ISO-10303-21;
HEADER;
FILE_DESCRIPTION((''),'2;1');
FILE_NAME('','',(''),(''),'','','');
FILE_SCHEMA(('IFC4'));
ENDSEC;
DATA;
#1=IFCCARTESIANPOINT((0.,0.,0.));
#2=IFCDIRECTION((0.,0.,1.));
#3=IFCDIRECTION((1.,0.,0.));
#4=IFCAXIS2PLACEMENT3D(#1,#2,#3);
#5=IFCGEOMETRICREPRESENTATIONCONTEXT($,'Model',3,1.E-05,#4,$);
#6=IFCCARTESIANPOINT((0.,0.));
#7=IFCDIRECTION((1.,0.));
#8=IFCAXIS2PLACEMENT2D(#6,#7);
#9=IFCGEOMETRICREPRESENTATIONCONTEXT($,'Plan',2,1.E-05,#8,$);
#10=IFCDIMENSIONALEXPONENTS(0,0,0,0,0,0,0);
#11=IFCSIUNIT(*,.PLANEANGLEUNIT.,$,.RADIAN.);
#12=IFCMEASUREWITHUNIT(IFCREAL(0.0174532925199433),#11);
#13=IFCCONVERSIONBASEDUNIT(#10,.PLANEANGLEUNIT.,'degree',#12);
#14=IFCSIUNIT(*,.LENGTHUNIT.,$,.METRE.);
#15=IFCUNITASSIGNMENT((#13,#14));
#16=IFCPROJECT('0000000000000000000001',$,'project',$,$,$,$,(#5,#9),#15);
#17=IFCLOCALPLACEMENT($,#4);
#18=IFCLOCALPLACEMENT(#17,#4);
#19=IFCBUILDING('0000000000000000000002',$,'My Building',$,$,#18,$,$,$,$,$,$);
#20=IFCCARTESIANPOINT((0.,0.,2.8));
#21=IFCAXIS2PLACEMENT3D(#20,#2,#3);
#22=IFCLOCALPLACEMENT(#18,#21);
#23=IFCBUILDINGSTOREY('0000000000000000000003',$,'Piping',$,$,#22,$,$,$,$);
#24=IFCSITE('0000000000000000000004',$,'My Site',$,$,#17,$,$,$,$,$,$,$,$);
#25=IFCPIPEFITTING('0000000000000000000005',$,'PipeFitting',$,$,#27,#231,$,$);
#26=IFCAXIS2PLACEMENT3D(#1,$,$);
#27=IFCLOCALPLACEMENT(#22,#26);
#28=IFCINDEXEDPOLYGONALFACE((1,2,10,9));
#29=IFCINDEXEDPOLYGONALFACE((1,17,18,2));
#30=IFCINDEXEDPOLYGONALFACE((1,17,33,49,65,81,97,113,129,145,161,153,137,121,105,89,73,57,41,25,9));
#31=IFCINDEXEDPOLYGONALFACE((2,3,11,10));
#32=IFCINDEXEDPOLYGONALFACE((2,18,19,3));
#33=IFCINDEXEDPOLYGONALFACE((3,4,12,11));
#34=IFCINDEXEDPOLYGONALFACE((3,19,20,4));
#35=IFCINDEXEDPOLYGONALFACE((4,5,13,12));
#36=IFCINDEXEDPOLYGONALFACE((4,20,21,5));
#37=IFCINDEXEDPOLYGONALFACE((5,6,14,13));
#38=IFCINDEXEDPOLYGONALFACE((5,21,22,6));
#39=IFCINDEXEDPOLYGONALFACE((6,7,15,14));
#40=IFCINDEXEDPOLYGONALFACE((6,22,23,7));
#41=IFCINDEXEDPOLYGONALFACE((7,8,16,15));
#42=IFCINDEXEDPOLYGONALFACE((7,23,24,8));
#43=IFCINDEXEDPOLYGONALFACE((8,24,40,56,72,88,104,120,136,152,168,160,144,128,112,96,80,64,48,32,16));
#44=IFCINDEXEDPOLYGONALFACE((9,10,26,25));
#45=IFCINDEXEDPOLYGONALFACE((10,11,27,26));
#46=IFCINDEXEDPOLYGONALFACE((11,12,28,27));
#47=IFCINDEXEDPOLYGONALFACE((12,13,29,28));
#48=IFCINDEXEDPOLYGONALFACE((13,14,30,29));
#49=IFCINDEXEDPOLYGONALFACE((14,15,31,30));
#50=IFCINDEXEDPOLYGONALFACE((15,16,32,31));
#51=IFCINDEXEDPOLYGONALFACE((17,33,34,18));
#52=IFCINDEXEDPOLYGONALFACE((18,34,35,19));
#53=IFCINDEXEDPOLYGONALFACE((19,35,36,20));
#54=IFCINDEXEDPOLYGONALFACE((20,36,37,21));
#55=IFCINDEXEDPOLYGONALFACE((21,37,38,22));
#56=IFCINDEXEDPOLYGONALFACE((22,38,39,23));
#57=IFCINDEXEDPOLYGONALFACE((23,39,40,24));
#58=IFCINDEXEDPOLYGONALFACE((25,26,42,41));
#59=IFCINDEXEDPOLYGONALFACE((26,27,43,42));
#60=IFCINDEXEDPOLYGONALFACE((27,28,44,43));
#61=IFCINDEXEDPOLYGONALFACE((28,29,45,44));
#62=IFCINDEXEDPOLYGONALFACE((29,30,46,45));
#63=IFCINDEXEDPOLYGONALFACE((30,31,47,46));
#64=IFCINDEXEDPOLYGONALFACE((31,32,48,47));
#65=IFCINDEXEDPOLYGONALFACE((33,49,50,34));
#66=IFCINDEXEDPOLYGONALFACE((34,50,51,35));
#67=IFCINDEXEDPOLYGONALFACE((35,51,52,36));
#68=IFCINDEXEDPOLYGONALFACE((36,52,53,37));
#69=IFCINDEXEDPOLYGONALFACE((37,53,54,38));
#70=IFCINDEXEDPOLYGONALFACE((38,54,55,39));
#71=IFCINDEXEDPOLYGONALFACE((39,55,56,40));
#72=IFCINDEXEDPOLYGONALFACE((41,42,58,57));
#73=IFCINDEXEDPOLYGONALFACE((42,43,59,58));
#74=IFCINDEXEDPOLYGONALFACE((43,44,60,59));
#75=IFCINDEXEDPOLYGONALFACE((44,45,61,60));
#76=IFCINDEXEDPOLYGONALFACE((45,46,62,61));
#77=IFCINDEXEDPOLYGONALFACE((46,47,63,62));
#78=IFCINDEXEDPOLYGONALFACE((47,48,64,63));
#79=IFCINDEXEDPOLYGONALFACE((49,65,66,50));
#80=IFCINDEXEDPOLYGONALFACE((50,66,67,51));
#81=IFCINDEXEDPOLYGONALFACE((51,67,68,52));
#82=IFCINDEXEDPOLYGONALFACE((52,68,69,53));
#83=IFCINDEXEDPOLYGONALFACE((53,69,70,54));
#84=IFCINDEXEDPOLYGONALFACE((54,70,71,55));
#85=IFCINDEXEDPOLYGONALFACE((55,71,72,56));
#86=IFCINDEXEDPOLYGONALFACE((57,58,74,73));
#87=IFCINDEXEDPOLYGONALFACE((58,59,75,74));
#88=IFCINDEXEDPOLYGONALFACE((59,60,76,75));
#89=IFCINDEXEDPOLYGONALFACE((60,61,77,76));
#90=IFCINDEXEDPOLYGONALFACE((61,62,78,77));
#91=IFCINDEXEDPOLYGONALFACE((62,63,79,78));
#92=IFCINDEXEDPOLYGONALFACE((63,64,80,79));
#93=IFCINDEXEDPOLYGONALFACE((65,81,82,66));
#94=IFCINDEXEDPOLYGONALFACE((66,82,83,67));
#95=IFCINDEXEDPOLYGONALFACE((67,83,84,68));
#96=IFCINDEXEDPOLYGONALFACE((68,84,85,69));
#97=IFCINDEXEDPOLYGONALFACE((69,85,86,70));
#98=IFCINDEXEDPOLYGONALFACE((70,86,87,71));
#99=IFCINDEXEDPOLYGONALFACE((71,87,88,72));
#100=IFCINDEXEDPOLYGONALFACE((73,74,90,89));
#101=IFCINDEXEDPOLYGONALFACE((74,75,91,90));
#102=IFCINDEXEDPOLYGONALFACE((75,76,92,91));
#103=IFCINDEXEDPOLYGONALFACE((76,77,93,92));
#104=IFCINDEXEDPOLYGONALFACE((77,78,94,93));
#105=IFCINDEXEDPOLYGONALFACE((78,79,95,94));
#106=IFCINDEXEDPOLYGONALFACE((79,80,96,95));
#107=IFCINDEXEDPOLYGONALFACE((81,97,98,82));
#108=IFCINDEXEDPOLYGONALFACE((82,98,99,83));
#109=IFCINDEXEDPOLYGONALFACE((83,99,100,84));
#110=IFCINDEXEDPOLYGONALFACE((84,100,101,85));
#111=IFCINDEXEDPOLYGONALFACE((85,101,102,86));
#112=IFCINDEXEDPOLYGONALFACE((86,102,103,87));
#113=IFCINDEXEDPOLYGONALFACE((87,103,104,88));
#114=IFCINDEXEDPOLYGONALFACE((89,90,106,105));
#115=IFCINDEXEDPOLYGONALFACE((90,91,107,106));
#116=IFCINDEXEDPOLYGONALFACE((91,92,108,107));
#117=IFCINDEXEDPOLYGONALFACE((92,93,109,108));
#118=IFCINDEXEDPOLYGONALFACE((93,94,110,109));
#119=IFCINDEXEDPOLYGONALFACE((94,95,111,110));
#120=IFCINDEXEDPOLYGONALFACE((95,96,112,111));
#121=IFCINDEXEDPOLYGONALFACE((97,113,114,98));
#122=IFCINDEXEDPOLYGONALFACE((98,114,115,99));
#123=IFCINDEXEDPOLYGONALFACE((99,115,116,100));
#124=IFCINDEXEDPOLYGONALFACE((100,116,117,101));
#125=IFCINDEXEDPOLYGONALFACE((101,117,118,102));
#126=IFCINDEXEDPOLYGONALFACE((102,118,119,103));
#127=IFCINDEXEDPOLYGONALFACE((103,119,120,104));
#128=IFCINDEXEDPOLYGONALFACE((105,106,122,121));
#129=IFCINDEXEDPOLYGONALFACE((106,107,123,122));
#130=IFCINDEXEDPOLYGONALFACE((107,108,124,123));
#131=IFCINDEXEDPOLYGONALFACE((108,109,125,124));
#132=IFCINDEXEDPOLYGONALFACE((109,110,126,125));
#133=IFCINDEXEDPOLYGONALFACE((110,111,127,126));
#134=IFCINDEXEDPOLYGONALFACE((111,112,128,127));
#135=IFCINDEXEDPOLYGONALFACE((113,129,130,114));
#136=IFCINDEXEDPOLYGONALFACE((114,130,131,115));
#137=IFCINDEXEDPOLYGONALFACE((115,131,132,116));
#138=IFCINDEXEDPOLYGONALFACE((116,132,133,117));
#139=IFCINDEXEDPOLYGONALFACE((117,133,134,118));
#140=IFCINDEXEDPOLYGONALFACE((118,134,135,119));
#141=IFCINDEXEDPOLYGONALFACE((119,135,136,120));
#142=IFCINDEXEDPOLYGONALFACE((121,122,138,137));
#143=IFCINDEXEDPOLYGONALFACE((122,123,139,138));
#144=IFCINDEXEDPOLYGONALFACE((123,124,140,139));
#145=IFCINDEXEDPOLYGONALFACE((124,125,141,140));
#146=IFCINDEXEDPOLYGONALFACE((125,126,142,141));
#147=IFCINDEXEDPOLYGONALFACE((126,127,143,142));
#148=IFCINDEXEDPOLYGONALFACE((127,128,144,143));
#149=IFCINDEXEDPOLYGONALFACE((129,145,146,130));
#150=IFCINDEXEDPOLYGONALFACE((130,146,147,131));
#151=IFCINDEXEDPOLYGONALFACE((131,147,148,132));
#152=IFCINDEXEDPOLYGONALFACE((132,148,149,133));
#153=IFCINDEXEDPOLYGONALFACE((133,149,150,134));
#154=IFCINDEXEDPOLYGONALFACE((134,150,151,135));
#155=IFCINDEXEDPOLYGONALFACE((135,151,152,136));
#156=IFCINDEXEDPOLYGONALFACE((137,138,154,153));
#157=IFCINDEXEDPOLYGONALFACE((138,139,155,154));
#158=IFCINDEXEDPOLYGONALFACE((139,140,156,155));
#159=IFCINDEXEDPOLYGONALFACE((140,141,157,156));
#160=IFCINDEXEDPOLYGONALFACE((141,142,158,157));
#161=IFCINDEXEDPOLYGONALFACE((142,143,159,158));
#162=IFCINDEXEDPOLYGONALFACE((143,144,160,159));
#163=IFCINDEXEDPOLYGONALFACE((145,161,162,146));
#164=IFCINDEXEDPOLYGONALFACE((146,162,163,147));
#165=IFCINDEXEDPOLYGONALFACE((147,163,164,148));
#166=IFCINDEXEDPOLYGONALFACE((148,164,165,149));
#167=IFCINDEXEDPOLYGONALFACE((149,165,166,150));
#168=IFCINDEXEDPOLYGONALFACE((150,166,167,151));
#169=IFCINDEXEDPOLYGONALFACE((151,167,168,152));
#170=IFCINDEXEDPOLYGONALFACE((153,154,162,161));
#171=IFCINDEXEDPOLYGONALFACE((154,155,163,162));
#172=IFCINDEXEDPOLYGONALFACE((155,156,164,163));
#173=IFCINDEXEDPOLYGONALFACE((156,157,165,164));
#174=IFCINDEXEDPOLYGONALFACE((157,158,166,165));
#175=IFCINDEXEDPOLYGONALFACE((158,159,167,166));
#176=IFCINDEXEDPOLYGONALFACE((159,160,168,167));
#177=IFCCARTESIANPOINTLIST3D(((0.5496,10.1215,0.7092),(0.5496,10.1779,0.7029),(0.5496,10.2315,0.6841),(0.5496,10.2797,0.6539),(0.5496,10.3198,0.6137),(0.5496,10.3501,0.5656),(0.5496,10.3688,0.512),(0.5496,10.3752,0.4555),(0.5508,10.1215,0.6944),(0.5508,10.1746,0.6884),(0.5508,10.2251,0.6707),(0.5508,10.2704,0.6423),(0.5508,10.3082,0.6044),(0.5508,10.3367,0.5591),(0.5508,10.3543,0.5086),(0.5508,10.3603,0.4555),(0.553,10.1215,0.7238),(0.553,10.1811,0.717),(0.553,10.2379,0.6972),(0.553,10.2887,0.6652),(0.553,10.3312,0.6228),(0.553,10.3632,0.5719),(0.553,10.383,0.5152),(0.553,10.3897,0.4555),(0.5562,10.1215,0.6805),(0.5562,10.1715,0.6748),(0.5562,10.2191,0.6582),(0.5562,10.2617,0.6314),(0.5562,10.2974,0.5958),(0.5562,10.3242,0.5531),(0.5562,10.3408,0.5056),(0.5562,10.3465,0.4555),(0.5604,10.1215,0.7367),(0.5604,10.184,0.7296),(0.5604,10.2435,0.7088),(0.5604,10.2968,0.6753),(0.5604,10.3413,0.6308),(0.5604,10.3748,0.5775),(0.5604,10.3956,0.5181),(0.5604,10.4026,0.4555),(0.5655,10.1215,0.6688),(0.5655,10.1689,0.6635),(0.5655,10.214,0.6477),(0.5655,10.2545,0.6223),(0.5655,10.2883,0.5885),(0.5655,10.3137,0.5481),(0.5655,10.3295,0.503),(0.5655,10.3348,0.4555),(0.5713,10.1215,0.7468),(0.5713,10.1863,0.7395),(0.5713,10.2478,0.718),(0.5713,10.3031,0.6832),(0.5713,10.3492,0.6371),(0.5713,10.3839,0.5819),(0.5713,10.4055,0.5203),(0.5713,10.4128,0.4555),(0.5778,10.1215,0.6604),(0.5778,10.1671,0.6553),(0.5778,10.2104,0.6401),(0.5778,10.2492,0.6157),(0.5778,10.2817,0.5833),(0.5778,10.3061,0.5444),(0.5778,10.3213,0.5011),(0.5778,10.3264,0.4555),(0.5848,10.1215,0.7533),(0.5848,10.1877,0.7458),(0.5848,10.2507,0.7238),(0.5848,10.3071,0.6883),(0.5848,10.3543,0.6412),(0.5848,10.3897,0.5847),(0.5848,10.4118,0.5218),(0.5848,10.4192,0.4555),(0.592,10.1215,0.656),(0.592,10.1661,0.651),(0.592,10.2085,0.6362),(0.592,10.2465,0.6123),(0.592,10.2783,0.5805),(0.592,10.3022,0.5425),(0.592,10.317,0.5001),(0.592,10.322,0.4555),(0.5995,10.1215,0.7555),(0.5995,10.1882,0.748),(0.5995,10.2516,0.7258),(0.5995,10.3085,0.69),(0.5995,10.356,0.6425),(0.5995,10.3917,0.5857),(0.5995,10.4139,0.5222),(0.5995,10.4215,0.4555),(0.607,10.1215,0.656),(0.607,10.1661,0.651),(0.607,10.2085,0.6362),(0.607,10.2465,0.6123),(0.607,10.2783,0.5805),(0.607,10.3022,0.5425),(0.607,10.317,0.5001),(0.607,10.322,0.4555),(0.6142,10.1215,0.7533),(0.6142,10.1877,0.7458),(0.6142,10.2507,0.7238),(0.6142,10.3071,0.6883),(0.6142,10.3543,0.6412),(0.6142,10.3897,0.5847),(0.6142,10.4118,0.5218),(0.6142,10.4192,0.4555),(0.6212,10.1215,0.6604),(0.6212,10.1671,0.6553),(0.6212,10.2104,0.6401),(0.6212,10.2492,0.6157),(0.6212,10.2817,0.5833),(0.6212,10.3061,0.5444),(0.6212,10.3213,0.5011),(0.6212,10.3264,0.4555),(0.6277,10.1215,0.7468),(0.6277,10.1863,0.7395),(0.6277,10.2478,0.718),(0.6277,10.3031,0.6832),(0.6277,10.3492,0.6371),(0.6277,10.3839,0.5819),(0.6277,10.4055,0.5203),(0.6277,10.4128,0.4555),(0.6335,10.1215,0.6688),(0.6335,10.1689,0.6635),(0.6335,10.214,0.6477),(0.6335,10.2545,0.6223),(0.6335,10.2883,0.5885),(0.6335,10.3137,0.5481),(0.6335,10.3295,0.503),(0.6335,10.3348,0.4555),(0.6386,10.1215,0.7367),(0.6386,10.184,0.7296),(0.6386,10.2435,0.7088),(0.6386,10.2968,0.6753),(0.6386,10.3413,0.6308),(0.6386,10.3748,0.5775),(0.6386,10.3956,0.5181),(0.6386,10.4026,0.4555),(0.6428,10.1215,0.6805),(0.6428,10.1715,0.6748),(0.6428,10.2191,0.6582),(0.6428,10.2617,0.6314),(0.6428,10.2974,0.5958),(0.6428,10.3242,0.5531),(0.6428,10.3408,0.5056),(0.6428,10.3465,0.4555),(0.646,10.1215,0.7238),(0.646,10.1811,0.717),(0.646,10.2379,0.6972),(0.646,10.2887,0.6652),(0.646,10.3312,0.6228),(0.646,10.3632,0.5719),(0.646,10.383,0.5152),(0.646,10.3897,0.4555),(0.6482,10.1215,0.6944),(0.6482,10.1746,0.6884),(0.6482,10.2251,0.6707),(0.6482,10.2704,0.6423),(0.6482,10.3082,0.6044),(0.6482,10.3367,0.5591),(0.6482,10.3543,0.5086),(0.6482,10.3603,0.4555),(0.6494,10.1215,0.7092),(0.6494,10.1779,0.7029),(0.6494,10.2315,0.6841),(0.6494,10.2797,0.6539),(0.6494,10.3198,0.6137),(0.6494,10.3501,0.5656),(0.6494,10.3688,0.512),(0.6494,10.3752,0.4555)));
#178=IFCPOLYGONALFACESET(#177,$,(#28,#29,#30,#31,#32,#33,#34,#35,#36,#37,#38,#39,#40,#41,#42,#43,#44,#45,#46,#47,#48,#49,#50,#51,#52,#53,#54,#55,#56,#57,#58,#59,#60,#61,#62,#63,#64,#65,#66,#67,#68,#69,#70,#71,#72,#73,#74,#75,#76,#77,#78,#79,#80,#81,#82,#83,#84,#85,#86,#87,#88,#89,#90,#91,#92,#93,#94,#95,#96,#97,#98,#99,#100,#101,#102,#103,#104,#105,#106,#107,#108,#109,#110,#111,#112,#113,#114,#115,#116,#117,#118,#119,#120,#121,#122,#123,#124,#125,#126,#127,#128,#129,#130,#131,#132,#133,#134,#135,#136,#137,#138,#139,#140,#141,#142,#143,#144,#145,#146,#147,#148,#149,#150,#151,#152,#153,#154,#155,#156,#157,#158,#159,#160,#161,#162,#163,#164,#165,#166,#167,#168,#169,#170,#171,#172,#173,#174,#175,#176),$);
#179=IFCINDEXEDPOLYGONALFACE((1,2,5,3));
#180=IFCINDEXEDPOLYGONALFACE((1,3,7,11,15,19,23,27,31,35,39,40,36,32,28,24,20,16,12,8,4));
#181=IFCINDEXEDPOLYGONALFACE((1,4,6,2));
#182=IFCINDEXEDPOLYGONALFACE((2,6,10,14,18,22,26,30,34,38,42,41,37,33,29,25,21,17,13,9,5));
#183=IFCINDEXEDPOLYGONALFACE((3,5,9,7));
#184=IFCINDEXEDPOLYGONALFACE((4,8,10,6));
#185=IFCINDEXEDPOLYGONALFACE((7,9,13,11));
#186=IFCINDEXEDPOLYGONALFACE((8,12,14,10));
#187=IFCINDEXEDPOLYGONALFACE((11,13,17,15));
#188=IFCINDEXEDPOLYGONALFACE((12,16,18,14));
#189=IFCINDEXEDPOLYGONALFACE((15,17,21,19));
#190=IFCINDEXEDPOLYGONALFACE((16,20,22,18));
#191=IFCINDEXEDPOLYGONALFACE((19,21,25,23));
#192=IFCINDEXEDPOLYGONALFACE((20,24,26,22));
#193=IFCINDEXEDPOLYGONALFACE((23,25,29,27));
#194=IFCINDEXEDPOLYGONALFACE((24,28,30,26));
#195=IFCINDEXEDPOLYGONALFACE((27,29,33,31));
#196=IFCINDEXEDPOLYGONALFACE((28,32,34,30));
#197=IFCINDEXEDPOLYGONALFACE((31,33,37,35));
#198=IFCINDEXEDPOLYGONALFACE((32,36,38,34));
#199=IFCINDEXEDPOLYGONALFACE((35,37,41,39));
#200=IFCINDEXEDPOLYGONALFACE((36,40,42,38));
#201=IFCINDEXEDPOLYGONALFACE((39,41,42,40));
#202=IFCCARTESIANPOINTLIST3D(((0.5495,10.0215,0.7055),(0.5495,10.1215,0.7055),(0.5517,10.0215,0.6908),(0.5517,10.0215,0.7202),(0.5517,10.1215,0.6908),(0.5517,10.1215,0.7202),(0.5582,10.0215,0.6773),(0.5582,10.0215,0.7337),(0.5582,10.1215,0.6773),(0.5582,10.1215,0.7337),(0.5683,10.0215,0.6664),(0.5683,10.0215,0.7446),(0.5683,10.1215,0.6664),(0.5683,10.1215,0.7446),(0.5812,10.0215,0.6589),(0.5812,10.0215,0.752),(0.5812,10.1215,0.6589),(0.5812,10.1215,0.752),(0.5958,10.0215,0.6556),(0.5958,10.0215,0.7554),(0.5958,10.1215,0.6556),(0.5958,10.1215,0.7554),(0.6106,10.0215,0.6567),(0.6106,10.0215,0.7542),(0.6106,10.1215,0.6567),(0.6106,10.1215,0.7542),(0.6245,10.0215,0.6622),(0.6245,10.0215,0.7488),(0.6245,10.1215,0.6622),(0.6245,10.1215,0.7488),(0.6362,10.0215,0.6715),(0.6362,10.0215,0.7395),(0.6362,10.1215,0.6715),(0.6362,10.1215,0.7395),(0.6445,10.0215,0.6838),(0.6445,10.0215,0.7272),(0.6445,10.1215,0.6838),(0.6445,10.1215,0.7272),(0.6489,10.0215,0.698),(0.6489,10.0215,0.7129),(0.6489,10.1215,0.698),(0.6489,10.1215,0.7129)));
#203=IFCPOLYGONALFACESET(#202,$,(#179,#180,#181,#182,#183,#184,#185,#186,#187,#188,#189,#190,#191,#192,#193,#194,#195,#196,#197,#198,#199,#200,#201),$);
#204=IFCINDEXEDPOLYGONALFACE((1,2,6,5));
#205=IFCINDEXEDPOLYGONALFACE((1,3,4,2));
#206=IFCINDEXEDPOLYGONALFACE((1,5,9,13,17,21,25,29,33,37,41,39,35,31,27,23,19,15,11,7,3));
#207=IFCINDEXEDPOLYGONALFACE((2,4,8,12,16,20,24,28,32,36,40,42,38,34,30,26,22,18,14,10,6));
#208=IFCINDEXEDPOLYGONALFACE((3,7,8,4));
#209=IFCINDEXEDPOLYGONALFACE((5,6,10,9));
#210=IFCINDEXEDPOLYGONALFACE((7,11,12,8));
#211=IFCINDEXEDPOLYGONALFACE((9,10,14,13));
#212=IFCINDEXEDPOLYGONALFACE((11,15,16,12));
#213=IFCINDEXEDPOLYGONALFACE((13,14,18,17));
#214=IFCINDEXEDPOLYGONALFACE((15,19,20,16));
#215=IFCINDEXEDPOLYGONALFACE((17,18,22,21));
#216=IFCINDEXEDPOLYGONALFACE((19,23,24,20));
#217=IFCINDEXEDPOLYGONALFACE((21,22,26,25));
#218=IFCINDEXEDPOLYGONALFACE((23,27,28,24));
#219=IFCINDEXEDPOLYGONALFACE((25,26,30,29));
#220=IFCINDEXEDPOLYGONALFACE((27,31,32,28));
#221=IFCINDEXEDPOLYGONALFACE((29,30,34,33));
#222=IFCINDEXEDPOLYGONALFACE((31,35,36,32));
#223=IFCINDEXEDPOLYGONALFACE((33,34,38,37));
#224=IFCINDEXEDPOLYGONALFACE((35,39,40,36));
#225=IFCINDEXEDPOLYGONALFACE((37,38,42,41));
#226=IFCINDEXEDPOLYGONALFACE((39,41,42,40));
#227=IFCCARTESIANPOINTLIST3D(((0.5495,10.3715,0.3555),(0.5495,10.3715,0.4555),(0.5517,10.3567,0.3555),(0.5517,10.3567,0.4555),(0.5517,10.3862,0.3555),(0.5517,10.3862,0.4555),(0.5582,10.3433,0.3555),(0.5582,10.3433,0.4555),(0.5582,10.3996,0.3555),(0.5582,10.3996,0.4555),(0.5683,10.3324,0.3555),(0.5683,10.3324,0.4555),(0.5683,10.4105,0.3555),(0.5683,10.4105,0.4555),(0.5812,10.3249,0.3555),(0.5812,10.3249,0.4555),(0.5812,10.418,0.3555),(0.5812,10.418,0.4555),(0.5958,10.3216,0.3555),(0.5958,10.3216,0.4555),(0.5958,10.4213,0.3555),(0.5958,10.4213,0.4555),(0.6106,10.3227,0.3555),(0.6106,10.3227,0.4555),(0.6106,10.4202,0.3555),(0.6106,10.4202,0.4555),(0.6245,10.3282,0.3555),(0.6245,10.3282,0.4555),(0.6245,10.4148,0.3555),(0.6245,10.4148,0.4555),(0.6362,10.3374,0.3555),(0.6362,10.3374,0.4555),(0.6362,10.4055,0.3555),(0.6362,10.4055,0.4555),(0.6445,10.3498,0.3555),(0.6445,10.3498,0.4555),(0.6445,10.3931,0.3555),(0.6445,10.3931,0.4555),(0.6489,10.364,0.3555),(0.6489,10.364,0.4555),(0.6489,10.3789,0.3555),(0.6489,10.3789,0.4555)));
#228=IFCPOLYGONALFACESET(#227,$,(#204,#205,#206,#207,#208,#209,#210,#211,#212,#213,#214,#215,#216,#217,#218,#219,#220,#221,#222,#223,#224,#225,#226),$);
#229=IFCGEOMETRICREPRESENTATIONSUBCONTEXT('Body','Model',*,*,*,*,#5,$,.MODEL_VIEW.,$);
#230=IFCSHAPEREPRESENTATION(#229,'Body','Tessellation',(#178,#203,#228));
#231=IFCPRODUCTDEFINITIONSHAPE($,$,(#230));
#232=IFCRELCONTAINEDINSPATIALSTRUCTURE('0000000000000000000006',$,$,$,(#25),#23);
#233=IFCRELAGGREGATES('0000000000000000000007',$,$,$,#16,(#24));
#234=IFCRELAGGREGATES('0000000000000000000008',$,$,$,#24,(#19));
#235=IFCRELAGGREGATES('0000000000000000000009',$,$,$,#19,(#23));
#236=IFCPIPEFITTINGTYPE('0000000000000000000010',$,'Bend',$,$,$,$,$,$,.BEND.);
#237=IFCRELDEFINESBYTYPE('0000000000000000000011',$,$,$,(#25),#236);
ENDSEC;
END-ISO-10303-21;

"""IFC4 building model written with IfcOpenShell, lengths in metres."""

from ifc_helpers import new_model, entity, si_unit, converted_unit, frame, origin_with_axes, origin_2d_with_axis, place, context, subcontext, project, spatial, circle, extrude, source, transform, mapped, type_object, type_shapes, element, save


model = new_model("IFC4")

# Units and contexts
model_context = context("Model", 3, precision=1e-05, world=origin_with_axes())
plan_context = context("Plan", 2, precision=1e-05, world=origin_2d_with_axis())
body_context = subcontext(model_context, "Body", "Model", "MODEL_VIEW")
ifc_project = project(units=[converted_unit("PLANEANGLEUNIT", "degree", entity("IfcReal", 0.0174532925199433), si_unit("PLANEANGLEUNIT", "RADIAN"), dimensions=[0, 0, 0, 0, 0, 0, 0]), si_unit("LENGTHUNIT", "METRE")], contexts=[model_context, plan_context])

# Site, building, storey
site_placement = place(None, origin_with_axes())
site = spatial("IfcSite", under=ifc_project, at=site_placement, Name="My Site")
building_placement = place(site_placement, origin_with_axes())
building = spatial("IfcBuilding", under=site, at=building_placement, Name="My Building")
storey_placement = place(building_placement, frame((0.0, 0.0, 2.8), z_axis=(0.0, 0.0, 1.0), x_axis=(1.0, 0.0, 0.0)))
storey = spatial("IfcBuildingStorey", under=building, at=storey_placement, Name="Piping")

# Pipe fitting
pipe_fitting_type_1 = type_object("IfcPipeFittingType", Name="Bend", PredefinedType="BEND")
shared_shape = source(origin_with_axes(), body_context, "Body", "SolidModel", [
    entity("IfcSweptDiskSolid", entity("IfcIndexedPolyCurve", entity("IfcCartesianPointList3D", [[0.0, 0.0, 0.1], [0.0, -0.0732, 0.2768], [0.0, -0.25, 0.35]]), [entity("IfcArcIndex", [1, 2, 3])]), 0.05),
    extrude(circle(Radius=0.05), origin_with_axes(), (0.0, 0.0, 1.0), 0.1),
    extrude(circle(Radius=0.05), frame((0.0, -0.25, 0.35), z_axis=(0.0, -1.0, 0.0), x_axis=(1.0, 0.0, 0.0)), (0.0, 0.0, 1.0), 0.1),
])
type_shapes(pipe_fitting_type_1, [shared_shape])
for number, where, z_axis, x_axis, name in (
    (1, (0.5995, 10.0215, 0.7055), (0.0, 1.0, 0.0), (-1.0, 0.0, 0.0), "PipeFitting"),
):
    element("IfcPipeFitting", number, at=place(storey_placement, frame(where, z_axis=z_axis, x_axis=x_axis)), inside=storey, type_object=pipe_fitting_type_1, Name=name, context=body_context, shape_type="MappedRepresentation", body=[
        mapped(shared_shape, transform((0.0, 0.0, 0.0), x_axis=(1.0, 0.0, 0.0), y_axis=(0.0, 1.0, 0.0), z_axis=(0.0, 0.0, 1.0), scale=1.0)),
    ])

save(model, "model.ifc")
